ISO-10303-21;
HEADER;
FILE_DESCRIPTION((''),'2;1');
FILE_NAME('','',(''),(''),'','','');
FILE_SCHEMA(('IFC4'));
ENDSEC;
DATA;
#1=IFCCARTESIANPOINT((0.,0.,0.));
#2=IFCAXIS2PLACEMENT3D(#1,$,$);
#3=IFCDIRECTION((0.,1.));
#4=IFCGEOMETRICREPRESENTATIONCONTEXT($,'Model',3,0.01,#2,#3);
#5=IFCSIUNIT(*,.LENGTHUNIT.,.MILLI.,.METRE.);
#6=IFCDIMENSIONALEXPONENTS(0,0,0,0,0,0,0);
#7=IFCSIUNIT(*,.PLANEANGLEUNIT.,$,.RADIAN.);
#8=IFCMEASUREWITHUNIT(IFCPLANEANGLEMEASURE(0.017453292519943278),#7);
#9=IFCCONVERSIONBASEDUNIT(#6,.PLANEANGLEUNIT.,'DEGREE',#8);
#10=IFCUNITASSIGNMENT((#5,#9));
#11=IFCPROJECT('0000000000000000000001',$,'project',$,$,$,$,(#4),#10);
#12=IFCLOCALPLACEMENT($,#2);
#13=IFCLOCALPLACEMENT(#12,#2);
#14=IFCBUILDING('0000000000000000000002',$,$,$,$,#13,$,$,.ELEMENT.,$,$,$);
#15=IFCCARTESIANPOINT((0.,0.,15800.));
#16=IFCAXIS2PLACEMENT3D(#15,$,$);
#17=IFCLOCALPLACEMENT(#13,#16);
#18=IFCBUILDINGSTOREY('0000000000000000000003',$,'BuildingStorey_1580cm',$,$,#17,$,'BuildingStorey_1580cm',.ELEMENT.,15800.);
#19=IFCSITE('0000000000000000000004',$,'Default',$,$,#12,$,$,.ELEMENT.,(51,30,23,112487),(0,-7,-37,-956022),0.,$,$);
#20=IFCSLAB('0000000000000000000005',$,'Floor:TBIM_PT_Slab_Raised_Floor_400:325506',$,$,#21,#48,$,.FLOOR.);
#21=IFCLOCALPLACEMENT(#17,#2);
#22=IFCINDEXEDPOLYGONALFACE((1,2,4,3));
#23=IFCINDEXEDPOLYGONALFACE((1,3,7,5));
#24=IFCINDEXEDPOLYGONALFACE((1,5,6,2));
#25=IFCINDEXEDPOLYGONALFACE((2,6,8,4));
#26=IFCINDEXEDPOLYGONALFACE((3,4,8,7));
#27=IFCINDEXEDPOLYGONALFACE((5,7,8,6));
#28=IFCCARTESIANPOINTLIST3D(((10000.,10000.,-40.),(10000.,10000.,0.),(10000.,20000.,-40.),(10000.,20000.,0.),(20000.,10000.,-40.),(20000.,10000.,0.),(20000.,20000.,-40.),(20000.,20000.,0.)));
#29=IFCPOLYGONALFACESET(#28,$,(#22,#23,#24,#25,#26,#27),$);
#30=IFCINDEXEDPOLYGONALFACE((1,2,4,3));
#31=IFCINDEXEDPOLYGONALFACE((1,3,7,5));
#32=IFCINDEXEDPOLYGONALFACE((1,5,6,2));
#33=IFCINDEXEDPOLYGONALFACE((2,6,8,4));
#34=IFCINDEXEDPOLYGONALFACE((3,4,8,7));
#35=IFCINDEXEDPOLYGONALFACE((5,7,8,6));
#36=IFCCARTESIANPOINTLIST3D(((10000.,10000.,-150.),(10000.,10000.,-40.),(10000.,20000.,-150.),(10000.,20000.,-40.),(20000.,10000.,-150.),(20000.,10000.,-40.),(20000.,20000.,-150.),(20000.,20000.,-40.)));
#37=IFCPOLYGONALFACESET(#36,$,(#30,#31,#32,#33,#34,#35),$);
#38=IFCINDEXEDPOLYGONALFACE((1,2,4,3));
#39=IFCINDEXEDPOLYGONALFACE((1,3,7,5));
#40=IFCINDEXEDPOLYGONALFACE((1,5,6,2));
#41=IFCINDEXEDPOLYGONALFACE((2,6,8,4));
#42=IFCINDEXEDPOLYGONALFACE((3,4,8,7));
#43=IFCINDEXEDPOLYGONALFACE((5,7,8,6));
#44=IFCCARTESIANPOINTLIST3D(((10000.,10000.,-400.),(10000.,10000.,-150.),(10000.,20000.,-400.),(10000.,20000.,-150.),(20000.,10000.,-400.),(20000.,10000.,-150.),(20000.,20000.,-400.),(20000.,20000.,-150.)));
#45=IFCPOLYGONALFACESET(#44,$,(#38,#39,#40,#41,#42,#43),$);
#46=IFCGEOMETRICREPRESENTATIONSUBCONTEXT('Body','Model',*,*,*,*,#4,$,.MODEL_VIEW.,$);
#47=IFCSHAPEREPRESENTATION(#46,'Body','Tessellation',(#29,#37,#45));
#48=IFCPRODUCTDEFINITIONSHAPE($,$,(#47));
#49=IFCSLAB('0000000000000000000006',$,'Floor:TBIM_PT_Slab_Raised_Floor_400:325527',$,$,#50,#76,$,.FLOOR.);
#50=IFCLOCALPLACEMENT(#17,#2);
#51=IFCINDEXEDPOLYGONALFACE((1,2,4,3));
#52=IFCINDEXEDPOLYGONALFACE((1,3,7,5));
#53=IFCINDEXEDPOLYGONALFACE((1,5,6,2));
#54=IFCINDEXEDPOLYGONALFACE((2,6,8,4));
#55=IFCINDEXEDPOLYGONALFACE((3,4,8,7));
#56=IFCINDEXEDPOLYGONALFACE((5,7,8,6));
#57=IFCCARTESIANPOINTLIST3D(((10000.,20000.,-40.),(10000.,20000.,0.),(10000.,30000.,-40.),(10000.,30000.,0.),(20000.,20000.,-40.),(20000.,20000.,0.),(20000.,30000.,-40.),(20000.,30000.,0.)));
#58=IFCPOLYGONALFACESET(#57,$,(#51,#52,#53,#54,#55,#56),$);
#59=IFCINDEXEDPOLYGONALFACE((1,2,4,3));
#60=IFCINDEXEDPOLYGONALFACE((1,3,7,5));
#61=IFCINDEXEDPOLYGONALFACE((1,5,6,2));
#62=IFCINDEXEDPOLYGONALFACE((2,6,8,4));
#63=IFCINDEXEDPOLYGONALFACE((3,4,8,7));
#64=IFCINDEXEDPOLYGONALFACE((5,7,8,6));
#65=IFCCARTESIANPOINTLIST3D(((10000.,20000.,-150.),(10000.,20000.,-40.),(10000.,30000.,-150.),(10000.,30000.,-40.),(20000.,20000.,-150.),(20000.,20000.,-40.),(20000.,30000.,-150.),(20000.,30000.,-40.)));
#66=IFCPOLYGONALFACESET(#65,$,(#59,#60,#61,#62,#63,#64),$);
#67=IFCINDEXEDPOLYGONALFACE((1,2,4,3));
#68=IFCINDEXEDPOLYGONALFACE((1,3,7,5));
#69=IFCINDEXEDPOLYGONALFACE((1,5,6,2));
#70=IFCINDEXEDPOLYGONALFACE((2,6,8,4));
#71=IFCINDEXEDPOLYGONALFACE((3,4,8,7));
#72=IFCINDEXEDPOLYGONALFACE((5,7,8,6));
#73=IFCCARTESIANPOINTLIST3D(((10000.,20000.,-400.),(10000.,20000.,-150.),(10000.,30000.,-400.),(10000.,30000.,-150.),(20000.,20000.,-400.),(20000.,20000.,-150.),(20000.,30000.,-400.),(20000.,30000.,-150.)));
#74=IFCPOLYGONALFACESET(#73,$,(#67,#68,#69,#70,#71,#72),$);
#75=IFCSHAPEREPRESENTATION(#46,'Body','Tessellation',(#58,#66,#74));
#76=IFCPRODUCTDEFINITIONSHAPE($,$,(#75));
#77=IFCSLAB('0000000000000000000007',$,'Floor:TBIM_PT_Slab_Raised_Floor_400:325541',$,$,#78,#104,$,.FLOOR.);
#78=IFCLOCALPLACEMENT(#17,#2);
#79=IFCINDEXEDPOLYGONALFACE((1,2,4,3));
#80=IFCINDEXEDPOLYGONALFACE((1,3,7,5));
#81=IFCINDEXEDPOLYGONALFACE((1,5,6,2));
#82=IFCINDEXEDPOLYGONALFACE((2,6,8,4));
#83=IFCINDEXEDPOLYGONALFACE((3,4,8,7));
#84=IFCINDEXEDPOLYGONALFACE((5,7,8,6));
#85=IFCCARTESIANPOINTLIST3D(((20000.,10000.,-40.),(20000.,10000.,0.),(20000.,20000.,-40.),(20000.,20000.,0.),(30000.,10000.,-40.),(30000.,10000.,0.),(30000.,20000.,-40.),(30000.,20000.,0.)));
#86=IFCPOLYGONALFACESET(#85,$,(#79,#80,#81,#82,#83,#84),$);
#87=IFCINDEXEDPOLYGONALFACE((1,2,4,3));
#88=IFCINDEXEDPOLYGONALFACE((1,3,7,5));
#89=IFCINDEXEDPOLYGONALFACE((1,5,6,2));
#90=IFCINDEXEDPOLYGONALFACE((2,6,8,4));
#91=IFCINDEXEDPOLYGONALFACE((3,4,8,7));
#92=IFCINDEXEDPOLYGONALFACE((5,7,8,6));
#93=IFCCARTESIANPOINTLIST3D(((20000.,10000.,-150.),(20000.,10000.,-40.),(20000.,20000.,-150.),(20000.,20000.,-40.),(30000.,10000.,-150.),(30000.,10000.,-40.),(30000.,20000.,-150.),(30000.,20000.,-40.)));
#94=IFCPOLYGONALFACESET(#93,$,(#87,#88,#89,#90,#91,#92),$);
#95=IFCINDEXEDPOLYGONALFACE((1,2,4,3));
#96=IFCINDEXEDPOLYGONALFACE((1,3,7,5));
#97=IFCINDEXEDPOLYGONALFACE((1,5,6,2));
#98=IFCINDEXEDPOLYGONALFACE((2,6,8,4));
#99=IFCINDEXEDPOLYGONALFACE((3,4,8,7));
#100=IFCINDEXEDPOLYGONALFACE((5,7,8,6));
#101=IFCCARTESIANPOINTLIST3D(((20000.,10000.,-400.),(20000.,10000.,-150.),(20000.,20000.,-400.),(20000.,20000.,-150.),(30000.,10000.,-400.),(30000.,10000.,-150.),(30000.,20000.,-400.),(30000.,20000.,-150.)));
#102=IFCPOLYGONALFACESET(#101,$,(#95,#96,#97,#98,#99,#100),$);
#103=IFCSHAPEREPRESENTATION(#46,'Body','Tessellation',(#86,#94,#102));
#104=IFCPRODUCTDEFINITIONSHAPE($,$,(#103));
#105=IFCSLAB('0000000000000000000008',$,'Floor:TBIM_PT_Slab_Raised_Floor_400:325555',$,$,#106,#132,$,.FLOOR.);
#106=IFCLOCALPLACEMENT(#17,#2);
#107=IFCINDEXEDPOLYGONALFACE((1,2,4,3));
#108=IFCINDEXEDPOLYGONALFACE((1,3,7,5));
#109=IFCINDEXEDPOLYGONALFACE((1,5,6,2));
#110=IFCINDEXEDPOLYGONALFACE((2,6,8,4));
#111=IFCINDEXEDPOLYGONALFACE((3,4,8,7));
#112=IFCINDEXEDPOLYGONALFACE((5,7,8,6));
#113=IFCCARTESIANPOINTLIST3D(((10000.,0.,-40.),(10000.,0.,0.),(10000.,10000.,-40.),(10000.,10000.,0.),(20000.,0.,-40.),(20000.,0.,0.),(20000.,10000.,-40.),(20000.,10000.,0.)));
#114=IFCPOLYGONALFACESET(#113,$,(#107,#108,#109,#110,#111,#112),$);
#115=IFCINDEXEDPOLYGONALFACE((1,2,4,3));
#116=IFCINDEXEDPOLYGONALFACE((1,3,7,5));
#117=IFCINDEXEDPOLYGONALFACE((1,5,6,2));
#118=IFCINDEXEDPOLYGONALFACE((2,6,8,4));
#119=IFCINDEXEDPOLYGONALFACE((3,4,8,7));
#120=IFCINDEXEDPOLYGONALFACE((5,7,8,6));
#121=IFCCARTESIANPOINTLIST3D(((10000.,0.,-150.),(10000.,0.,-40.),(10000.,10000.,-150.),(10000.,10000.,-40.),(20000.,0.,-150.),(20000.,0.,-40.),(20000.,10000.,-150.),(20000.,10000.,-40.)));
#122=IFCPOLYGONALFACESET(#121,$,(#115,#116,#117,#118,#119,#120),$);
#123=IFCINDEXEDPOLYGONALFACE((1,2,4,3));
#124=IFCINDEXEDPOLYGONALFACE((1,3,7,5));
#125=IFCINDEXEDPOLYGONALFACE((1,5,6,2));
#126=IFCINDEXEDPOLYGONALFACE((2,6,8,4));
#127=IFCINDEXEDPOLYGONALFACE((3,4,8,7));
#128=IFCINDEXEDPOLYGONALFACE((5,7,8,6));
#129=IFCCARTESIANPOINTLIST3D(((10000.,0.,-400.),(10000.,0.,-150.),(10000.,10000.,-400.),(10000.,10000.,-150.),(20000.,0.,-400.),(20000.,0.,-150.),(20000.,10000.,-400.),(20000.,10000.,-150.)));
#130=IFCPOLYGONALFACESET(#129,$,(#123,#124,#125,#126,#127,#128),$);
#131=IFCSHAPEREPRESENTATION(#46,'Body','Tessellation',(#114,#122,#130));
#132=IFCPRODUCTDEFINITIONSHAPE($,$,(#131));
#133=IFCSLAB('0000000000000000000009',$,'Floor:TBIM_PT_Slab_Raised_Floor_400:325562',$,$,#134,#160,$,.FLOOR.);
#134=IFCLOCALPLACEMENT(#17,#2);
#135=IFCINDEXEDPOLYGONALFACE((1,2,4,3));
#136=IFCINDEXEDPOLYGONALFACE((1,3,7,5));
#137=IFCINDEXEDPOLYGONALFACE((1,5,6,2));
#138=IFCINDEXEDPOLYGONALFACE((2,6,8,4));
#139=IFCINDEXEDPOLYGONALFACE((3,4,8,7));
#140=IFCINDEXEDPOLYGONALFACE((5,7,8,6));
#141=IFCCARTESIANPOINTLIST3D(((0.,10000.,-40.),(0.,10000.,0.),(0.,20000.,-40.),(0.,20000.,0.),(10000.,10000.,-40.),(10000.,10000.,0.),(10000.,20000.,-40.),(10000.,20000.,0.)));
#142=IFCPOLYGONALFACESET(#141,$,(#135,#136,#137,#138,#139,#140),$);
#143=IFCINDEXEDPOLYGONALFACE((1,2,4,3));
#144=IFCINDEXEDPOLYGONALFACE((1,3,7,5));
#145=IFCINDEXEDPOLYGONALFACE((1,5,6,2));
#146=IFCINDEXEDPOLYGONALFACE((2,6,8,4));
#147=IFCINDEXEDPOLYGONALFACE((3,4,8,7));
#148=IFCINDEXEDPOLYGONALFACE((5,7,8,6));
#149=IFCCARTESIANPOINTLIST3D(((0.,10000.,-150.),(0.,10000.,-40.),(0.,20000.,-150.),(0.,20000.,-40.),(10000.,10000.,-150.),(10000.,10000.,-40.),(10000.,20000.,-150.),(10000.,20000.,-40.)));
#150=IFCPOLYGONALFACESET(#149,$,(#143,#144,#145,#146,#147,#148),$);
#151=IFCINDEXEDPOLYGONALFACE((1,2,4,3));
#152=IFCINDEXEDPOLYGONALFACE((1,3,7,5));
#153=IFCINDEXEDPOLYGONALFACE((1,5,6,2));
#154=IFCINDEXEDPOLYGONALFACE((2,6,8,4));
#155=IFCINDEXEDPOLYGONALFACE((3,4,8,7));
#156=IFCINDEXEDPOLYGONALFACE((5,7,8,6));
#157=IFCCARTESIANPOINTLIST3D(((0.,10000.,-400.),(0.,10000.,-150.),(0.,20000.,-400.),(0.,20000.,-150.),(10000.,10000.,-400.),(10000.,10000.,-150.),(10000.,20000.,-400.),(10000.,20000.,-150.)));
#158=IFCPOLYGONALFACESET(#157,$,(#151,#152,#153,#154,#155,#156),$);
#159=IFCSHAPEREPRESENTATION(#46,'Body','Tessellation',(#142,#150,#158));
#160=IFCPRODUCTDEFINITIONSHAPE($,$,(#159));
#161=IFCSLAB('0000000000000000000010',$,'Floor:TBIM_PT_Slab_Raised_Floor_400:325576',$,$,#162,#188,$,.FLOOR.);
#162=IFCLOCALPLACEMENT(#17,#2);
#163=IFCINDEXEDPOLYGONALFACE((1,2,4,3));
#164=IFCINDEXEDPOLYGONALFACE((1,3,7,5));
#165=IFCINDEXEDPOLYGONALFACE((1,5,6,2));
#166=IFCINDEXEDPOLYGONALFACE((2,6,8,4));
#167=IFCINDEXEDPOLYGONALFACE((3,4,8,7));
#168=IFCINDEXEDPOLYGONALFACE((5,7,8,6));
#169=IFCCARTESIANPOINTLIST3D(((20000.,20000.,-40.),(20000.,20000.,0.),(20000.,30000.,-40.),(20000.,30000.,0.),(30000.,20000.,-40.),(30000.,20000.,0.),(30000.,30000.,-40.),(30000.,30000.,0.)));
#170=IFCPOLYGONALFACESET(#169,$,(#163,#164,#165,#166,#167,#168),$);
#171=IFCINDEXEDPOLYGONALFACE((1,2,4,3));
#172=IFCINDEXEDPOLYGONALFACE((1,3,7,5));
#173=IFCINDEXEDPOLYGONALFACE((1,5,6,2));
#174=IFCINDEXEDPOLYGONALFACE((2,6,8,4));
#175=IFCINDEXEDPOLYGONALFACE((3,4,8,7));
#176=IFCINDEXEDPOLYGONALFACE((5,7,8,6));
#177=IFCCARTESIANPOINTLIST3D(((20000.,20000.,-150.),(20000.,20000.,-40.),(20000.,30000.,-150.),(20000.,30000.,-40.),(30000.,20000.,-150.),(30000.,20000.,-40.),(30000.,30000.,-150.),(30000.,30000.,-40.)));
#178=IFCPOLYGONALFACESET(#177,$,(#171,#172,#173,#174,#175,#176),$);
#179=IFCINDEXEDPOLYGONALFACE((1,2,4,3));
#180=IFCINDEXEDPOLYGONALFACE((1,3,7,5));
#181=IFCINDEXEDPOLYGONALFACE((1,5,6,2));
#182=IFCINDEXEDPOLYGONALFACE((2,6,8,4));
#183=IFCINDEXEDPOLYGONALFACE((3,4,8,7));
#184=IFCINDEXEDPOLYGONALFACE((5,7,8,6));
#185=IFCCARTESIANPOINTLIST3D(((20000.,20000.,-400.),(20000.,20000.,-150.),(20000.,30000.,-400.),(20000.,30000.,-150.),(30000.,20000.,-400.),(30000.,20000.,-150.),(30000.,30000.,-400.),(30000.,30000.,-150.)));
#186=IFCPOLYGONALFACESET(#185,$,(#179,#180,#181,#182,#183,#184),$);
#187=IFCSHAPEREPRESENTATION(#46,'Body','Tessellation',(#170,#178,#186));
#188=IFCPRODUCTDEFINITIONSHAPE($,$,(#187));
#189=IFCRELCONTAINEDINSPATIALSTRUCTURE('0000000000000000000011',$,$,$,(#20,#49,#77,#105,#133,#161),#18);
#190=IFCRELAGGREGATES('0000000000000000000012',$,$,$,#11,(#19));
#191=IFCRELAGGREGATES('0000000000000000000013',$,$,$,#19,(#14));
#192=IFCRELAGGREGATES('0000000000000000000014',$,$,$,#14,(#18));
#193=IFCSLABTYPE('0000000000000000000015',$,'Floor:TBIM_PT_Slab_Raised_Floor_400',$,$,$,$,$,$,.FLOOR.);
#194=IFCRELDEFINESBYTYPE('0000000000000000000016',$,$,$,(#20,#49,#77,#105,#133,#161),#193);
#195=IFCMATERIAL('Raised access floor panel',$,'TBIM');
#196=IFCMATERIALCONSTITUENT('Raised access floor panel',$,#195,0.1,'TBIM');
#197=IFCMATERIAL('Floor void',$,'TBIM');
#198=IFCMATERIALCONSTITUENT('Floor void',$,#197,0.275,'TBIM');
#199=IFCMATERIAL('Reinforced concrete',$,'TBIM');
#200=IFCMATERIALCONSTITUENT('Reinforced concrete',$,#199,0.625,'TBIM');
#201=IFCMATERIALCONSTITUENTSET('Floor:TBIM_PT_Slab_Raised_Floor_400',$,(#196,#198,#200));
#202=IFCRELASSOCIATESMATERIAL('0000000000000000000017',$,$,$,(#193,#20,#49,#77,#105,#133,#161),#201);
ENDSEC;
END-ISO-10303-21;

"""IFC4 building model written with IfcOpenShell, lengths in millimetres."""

from ifc_helpers import new_model, entity, si_unit, converted_unit, direction, frame, origin, place, context, subcontext, project, spatial, indexed_curve, outline, extrude, material, constituent, constituent_set, type_object, element, save


model = new_model("IFC4")

# Units and contexts
model_context = context("Model", 3, precision=0.01, world=origin(), true_north=direction((0.0, 1.0)))
body_context = subcontext(model_context, "Body", "Model", "MODEL_VIEW")
ifc_project = project(units=[si_unit("LENGTHUNIT", "METRE", prefix="MILLI"), converted_unit("PLANEANGLEUNIT", "DEGREE", entity("IfcPlaneAngleMeasure", 0.017453292519943278), si_unit("PLANEANGLEUNIT", "RADIAN"), dimensions=[0, 0, 0, 0, 0, 0, 0])], contexts=[model_context])

# Site, building, storey
site_placement = place(None, origin())
site = spatial("IfcSite", under=ifc_project, at=site_placement, Name="Default", CompositionType="ELEMENT", RefLatitude=(51, 30, 23, 112487), RefLongitude=(0, -7, -37, -956022), RefElevation=0.0)
building_placement = place(site_placement, origin())
building = spatial("IfcBuilding", under=site, at=building_placement, CompositionType="ELEMENT")
storey_placement = place(building_placement, frame((0.0, 0.0, 15800.0)))
storey = spatial("IfcBuildingStorey", under=building, at=storey_placement, Name="BuildingStorey_1580cm", LongName="BuildingStorey_1580cm", CompositionType="ELEMENT", Elevation=15800.0)

# Slabs
ifc_material_1 = material(Name="Raised access floor panel", Category="TBIM")
ifc_constituent_1 = constituent(ifc_material_1, Name="Raised access floor panel", Category="TBIM", fraction=0.1)
ifc_material_2 = material(Name="Floor void", Category="TBIM")
ifc_constituent_2 = constituent(ifc_material_2, Name="Floor void", Category="TBIM", fraction=0.275)
ifc_material_3 = material(Name="Reinforced concrete", Category="TBIM")
ifc_constituent_3 = constituent(ifc_material_3, Name="Reinforced concrete", Category="TBIM", fraction=0.625)
ifc_constituent_set_1 = constituent_set(constituents=[ifc_constituent_1, ifc_constituent_2, ifc_constituent_3], Name="Floor:TBIM_PT_Slab_Raised_Floor_400")
slab_type = type_object("IfcSlabType", Name="Floor:TBIM_PT_Slab_Raised_Floor_400", PredefinedType="FLOOR", material=ifc_constituent_set_1)
slab_1_placement = place(storey_placement, origin())
element("IfcSlab", 1, at=slab_1_placement, inside=storey, type_object=slab_type, material=ifc_constituent_set_1, Name="Floor:TBIM_PT_Slab_Raised_Floor_400:325506", PredefinedType="FLOOR", context=body_context, shape_type="SweptSolid", body=[
    extrude(outline(indexed_curve([(-5000.0, -5000.0), (5000.0, -5000.0), (5000.0, 5000.0), (-5000.0, 5000.0), (-5000.0, -5000.0)], self_intersect=False)), frame((15000.0, 15000.0, -40.0), z_axis=(0.0, 0.0, 1.0), x_axis=(-1.0, 0.0, 0.0)), (0.0, 0.0, 1.0), 40.0),
    extrude(outline(indexed_curve([(-5000.0, -5000.0), (5000.0, -5000.0), (5000.0, 5000.0), (-5000.0, 5000.0), (-5000.0, -5000.0)], self_intersect=False)), frame((15000.0, 15000.0, -150.0), z_axis=(0.0, 0.0, 1.0), x_axis=(-1.0, 0.0, 0.0)), (0.0, 0.0, 1.0), 110.0),
    extrude(outline(indexed_curve([(-5000.0, -5000.0), (5000.0, -5000.0), (5000.0, 5000.0), (-5000.0, 5000.0), (-5000.0, -5000.0)], self_intersect=False)), frame((15000.0, 15000.0, -400.0), z_axis=(0.0, 0.0, 1.0), x_axis=(-1.0, 0.0, 0.0)), (0.0, 0.0, 1.0), 250.0),
])
slab_2_placement = place(storey_placement, origin())
element("IfcSlab", 2, at=slab_2_placement, inside=storey, type_object=slab_type, material=ifc_constituent_set_1, Name="Floor:TBIM_PT_Slab_Raised_Floor_400:325527", PredefinedType="FLOOR", context=body_context, shape_type="SweptSolid", body=[
    extrude(outline(indexed_curve([(-5000.0, -5000.0), (5000.0, -5000.0), (5000.0, 5000.0), (-5000.0, 5000.0), (-5000.0, -5000.0)], self_intersect=False)), frame((15000.0, 25000.0, -40.0), z_axis=(0.0, 0.0, 1.0), x_axis=(-1.0, 0.0, 0.0)), (0.0, 0.0, 1.0), 40.0),
    extrude(outline(indexed_curve([(-5000.0, -5000.0), (5000.0, -5000.0), (5000.0, 5000.0), (-5000.0, 5000.0), (-5000.0, -5000.0)], self_intersect=False)), frame((15000.0, 25000.0, -150.0), z_axis=(0.0, 0.0, 1.0), x_axis=(-1.0, 0.0, 0.0)), (0.0, 0.0, 1.0), 110.0),
    extrude(outline(indexed_curve([(-5000.0, -5000.0), (5000.0, -5000.0), (5000.0, 5000.0), (-5000.0, 5000.0), (-5000.0, -5000.0)], self_intersect=False)), frame((15000.0, 25000.0, -400.0), z_axis=(0.0, 0.0, 1.0), x_axis=(-1.0, 0.0, 0.0)), (0.0, 0.0, 1.0), 250.0),
])
slab_3_placement = place(storey_placement, origin())
element("IfcSlab", 3, at=slab_3_placement, inside=storey, type_object=slab_type, material=ifc_constituent_set_1, Name="Floor:TBIM_PT_Slab_Raised_Floor_400:325541", PredefinedType="FLOOR", context=body_context, shape_type="SweptSolid", body=[
    extrude(outline(indexed_curve([(-5000.0, -5000.0), (5000.0, -5000.0), (5000.0, 5000.0), (-5000.0, 5000.0), (-5000.0, -5000.0)], self_intersect=False)), frame((25000.0, 15000.0, -40.0), z_axis=(0.0, 0.0, 1.0), x_axis=(-1.0, 0.0, 0.0)), (0.0, 0.0, 1.0), 40.0),
    extrude(outline(indexed_curve([(-5000.0, -5000.0), (5000.0, -5000.0), (5000.0, 5000.0), (-5000.0, 5000.0), (-5000.0, -5000.0)], self_intersect=False)), frame((25000.0, 15000.0, -150.0), z_axis=(0.0, 0.0, 1.0), x_axis=(-1.0, 0.0, 0.0)), (0.0, 0.0, 1.0), 110.0),
    extrude(outline(indexed_curve([(-5000.0, -5000.0), (5000.0, -5000.0), (5000.0, 5000.0), (-5000.0, 5000.0), (-5000.0, -5000.0)], self_intersect=False)), frame((25000.0, 15000.0, -400.0), z_axis=(0.0, 0.0, 1.0), x_axis=(-1.0, 0.0, 0.0)), (0.0, 0.0, 1.0), 250.0),
])
slab_4_placement = place(storey_placement, origin())
element("IfcSlab", 4, at=slab_4_placement, inside=storey, type_object=slab_type, material=ifc_constituent_set_1, Name="Floor:TBIM_PT_Slab_Raised_Floor_400:325555", PredefinedType="FLOOR", context=body_context, shape_type="SweptSolid", body=[
    extrude(outline(indexed_curve([(-5000.0, -5000.0), (5000.0, -5000.0), (5000.0, 5000.0), (-5000.0, 5000.0), (-5000.0, -5000.0)], self_intersect=False)), frame((15000.0, 5000.0, -40.0), z_axis=(0.0, 0.0, 1.0), x_axis=(0.0, 1.0, 0.0)), (0.0, 0.0, 1.0), 40.0),
    extrude(outline(indexed_curve([(-5000.0, -5000.0), (5000.0, -5000.0), (5000.0, 5000.0), (-5000.0, 5000.0), (-5000.0, -5000.0)], self_intersect=False)), frame((15000.0, 5000.0, -150.0), z_axis=(0.0, 0.0, 1.0), x_axis=(0.0, 1.0, 0.0)), (0.0, 0.0, 1.0), 110.0),
    extrude(outline(indexed_curve([(-5000.0, -5000.0), (5000.0, -5000.0), (5000.0, 5000.0), (-5000.0, 5000.0), (-5000.0, -5000.0)], self_intersect=False)), frame((15000.0, 5000.0, -400.0), z_axis=(0.0, 0.0, 1.0), x_axis=(0.0, 1.0, 0.0)), (0.0, 0.0, 1.0), 250.0),
])
slab_5_placement = place(storey_placement, origin())
element("IfcSlab", 5, at=slab_5_placement, inside=storey, type_object=slab_type, material=ifc_constituent_set_1, Name="Floor:TBIM_PT_Slab_Raised_Floor_400:325562", PredefinedType="FLOOR", context=body_context, shape_type="SweptSolid", body=[
    extrude(outline(indexed_curve([(-5000.0, -5000.0), (5000.0, -5000.0), (5000.0, 5000.0), (-5000.0, 5000.0), (-5000.0, -5000.0)], self_intersect=False)), frame((5000.0, 15000.0, -40.0), z_axis=(0.0, 0.0, 1.0), x_axis=(0.0, 1.0, 0.0)), (0.0, 0.0, 1.0), 40.0),
    extrude(outline(indexed_curve([(-5000.0, -5000.0), (5000.0, -5000.0), (5000.0, 5000.0), (-5000.0, 5000.0), (-5000.0, -5000.0)], self_intersect=False)), frame((5000.0, 15000.0, -150.0), z_axis=(0.0, 0.0, 1.0), x_axis=(0.0, 1.0, 0.0)), (0.0, 0.0, 1.0), 110.0),
    extrude(outline(indexed_curve([(-5000.0, -5000.0), (5000.0, -5000.0), (5000.0, 5000.0), (-5000.0, 5000.0), (-5000.0, -5000.0)], self_intersect=False)), frame((5000.0, 15000.0, -400.0), z_axis=(0.0, 0.0, 1.0), x_axis=(0.0, 1.0, 0.0)), (0.0, 0.0, 1.0), 250.0),
])
slab_6_placement = place(storey_placement, origin())
element("IfcSlab", 6, at=slab_6_placement, inside=storey, type_object=slab_type, material=ifc_constituent_set_1, Name="Floor:TBIM_PT_Slab_Raised_Floor_400:325576", PredefinedType="FLOOR", context=body_context, shape_type="SweptSolid", body=[
    extrude(outline(indexed_curve([(-5000.0, -5000.0), (5000.0, -5000.0), (5000.0, 5000.0), (-5000.0, 5000.0), (-5000.0, -5000.0)], self_intersect=False)), frame((25000.0, 25000.0, -40.0), z_axis=(0.0, 0.0, 1.0), x_axis=(-1.0, 0.0, 0.0)), (0.0, 0.0, 1.0), 40.0),
    extrude(outline(indexed_curve([(-5000.0, -5000.0), (5000.0, -5000.0), (5000.0, 5000.0), (-5000.0, 5000.0), (-5000.0, -5000.0)], self_intersect=False)), frame((25000.0, 25000.0, -150.0), z_axis=(0.0, 0.0, 1.0), x_axis=(-1.0, 0.0, 0.0)), (0.0, 0.0, 1.0), 110.0),
    extrude(outline(indexed_curve([(-5000.0, -5000.0), (5000.0, -5000.0), (5000.0, 5000.0), (-5000.0, 5000.0), (-5000.0, -5000.0)], self_intersect=False)), frame((25000.0, 25000.0, -400.0), z_axis=(0.0, 0.0, 1.0), x_axis=(-1.0, 0.0, 0.0)), (0.0, 0.0, 1.0), 250.0),
])

save(model, "model.ifc")
